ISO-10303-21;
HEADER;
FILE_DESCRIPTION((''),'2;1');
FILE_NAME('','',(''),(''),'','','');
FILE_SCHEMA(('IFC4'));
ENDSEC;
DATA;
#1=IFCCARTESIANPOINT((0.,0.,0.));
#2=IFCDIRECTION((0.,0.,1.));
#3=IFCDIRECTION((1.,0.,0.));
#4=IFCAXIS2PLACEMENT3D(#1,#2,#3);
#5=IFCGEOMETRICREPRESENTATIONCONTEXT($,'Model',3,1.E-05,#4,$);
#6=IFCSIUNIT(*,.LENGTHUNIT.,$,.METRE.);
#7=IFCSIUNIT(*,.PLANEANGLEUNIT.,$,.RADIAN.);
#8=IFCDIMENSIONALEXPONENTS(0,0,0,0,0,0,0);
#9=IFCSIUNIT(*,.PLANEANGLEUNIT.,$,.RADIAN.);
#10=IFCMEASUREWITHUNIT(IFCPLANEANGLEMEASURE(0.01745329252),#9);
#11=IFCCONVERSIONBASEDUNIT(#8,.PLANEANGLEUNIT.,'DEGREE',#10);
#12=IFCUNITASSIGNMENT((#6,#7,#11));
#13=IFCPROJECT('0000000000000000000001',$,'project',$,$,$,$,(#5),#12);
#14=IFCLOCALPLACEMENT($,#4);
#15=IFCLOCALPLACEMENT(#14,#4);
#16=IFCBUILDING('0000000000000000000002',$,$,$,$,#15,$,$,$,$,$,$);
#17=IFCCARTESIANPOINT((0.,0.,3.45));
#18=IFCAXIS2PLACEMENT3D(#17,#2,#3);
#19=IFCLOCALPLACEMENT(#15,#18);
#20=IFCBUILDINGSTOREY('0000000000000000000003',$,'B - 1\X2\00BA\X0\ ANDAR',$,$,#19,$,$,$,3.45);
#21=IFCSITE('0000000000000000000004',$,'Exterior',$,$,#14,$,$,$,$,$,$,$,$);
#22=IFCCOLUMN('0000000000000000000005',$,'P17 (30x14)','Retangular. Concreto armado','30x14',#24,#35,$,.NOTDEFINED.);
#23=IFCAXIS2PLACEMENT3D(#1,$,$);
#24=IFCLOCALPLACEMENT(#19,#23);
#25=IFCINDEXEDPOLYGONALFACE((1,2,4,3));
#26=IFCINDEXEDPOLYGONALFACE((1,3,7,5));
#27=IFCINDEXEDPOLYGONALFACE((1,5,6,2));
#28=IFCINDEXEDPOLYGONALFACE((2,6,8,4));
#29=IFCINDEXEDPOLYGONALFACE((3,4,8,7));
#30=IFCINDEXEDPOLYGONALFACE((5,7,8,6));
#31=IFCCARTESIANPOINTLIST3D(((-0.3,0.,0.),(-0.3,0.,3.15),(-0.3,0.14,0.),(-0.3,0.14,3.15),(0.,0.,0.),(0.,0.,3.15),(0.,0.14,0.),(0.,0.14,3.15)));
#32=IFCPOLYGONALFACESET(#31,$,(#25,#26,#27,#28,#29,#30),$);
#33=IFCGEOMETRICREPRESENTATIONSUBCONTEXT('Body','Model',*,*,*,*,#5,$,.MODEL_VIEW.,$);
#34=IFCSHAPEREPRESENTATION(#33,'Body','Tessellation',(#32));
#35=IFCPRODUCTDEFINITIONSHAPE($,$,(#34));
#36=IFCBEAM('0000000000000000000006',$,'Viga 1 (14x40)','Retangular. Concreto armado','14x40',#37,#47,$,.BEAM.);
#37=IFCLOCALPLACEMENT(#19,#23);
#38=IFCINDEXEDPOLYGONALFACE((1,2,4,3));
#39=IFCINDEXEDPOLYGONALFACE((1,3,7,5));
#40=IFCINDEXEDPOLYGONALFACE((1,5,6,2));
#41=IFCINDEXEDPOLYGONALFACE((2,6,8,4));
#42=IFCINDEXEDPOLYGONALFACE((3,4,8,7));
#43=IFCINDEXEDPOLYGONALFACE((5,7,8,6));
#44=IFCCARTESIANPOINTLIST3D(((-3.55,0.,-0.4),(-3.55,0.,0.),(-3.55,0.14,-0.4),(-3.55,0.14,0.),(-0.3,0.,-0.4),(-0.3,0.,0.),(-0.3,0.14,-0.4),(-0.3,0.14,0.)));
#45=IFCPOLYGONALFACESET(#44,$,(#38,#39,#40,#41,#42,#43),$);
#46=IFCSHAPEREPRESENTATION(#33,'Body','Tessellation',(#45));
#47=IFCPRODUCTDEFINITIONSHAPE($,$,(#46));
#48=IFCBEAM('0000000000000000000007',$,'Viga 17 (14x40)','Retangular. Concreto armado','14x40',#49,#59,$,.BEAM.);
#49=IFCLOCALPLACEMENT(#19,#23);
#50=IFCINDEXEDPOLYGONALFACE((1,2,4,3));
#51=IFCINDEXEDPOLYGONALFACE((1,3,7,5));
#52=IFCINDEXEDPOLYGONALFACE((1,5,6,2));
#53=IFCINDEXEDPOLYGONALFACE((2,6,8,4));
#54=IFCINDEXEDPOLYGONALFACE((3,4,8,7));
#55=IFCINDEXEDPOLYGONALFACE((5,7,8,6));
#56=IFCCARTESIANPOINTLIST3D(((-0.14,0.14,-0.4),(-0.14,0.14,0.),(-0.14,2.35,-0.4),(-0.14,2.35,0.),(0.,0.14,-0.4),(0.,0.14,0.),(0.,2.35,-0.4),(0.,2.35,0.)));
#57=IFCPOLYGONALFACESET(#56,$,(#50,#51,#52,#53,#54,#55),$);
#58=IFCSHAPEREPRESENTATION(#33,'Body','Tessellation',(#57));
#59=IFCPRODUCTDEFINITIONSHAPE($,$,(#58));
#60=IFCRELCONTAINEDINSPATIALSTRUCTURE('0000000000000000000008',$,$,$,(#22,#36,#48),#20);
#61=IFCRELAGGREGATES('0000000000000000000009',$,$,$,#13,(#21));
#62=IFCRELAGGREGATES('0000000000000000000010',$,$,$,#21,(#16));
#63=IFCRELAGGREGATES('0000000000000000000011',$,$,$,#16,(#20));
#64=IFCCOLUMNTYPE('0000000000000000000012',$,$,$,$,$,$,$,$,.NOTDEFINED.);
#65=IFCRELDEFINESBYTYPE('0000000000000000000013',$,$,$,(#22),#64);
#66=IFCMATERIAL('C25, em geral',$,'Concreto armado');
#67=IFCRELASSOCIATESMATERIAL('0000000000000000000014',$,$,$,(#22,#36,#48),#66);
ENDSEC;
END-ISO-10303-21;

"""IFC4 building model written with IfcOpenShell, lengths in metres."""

from ifc_helpers import new_model, entity, si_unit, converted_unit, frame, frame_2d, origin_with_axes, origin_2d_with_axis, place, context, subcontext, project, spatial, rectangle, extrude, material, type_object, element, save


model = new_model("IFC4")

# Units and contexts
model_context = context("Model", 3, precision=1e-05, world=origin_with_axes())
body_context = subcontext(model_context, "Body", "Model", "MODEL_VIEW")
ifc_project = project(units=[si_unit("LENGTHUNIT", "METRE"), si_unit("PLANEANGLEUNIT", "RADIAN"), converted_unit("PLANEANGLEUNIT", "DEGREE", entity("IfcPlaneAngleMeasure", 0.01745329252), si_unit("PLANEANGLEUNIT", "RADIAN"), dimensions=[0, 0, 0, 0, 0, 0, 0])], contexts=[model_context])

# Site, building, storey
site_placement = place(None, origin_with_axes())
site = spatial("IfcSite", under=ifc_project, at=site_placement, Name="Exterior")
building_placement = place(site_placement, origin_with_axes())
building = spatial("IfcBuilding", under=site, at=building_placement)
storey_placement = place(building_placement, frame((0.0, 0.0, 3.45), z_axis=(0.0, 0.0, 1.0), x_axis=(1.0, 0.0, 0.0)))
storey = spatial("IfcBuildingStorey", under=building, at=storey_placement, Name="B - 1º ANDAR", Elevation=3.45)

# Column
ifc_material = material(Name="C25, em geral", Category="Concreto armado")
column_type = type_object("IfcColumnType", PredefinedType="NOTDEFINED")
column_placement = place(storey_placement, frame((-0.15, 0.07, 0.0), z_axis=(0.0, 0.0, 1.0), x_axis=(1.0, 0.0, 0.0)))
element("IfcColumn", 1, at=column_placement, inside=storey, type_object=column_type, material=ifc_material, Name="P17 (30x14)", Description="Retangular. Concreto armado", ObjectType="30x14", PredefinedType="NOTDEFINED", context=body_context, shape_type="SweptSolid", body=[
    extrude(rectangle(XDim=0.3, YDim=0.14, at=origin_2d_with_axis()), origin_with_axes(), (0.0, 0.0, 1.0), 3.15),
])

# Beams
beam_1_placement = place(storey_placement, frame((-3.55, 0.07, 0.0), z_axis=(1.0, 0.0, 0.0), x_axis=(0.0, 1.0, 0.0)))
element("IfcBeam", 2, at=beam_1_placement, inside=storey, material=ifc_material, Name="Viga 1 (14x40)", Description="Retangular. Concreto armado", ObjectType="14x40", PredefinedType="BEAM", context=body_context, shape_type="SweptSolid", body=[
    extrude(rectangle(XDim=0.14, YDim=0.4, at=frame_2d((0.0, -0.2), x_axis=(1.0, 0.0))), origin_with_axes(), (0.0, 0.0, 1.0), 3.25),
])
beam_2_placement = place(storey_placement, frame((-0.07, 0.14, 0.0), z_axis=(0.0, 1.0, 0.0), x_axis=(-1.0, 0.0, 0.0)))
element("IfcBeam", 3, at=beam_2_placement, inside=storey, material=ifc_material, Name="Viga 17 (14x40)", Description="Retangular. Concreto armado", ObjectType="14x40", PredefinedType="BEAM", context=body_context, shape_type="SweptSolid", body=[
    extrude(rectangle(XDim=0.14, YDim=0.4, at=frame_2d((0.0, -0.2), x_axis=(1.0, 0.0))), origin_with_axes(), (0.0, 0.0, 1.0), 2.21),
])

save(model, "model.ifc")
